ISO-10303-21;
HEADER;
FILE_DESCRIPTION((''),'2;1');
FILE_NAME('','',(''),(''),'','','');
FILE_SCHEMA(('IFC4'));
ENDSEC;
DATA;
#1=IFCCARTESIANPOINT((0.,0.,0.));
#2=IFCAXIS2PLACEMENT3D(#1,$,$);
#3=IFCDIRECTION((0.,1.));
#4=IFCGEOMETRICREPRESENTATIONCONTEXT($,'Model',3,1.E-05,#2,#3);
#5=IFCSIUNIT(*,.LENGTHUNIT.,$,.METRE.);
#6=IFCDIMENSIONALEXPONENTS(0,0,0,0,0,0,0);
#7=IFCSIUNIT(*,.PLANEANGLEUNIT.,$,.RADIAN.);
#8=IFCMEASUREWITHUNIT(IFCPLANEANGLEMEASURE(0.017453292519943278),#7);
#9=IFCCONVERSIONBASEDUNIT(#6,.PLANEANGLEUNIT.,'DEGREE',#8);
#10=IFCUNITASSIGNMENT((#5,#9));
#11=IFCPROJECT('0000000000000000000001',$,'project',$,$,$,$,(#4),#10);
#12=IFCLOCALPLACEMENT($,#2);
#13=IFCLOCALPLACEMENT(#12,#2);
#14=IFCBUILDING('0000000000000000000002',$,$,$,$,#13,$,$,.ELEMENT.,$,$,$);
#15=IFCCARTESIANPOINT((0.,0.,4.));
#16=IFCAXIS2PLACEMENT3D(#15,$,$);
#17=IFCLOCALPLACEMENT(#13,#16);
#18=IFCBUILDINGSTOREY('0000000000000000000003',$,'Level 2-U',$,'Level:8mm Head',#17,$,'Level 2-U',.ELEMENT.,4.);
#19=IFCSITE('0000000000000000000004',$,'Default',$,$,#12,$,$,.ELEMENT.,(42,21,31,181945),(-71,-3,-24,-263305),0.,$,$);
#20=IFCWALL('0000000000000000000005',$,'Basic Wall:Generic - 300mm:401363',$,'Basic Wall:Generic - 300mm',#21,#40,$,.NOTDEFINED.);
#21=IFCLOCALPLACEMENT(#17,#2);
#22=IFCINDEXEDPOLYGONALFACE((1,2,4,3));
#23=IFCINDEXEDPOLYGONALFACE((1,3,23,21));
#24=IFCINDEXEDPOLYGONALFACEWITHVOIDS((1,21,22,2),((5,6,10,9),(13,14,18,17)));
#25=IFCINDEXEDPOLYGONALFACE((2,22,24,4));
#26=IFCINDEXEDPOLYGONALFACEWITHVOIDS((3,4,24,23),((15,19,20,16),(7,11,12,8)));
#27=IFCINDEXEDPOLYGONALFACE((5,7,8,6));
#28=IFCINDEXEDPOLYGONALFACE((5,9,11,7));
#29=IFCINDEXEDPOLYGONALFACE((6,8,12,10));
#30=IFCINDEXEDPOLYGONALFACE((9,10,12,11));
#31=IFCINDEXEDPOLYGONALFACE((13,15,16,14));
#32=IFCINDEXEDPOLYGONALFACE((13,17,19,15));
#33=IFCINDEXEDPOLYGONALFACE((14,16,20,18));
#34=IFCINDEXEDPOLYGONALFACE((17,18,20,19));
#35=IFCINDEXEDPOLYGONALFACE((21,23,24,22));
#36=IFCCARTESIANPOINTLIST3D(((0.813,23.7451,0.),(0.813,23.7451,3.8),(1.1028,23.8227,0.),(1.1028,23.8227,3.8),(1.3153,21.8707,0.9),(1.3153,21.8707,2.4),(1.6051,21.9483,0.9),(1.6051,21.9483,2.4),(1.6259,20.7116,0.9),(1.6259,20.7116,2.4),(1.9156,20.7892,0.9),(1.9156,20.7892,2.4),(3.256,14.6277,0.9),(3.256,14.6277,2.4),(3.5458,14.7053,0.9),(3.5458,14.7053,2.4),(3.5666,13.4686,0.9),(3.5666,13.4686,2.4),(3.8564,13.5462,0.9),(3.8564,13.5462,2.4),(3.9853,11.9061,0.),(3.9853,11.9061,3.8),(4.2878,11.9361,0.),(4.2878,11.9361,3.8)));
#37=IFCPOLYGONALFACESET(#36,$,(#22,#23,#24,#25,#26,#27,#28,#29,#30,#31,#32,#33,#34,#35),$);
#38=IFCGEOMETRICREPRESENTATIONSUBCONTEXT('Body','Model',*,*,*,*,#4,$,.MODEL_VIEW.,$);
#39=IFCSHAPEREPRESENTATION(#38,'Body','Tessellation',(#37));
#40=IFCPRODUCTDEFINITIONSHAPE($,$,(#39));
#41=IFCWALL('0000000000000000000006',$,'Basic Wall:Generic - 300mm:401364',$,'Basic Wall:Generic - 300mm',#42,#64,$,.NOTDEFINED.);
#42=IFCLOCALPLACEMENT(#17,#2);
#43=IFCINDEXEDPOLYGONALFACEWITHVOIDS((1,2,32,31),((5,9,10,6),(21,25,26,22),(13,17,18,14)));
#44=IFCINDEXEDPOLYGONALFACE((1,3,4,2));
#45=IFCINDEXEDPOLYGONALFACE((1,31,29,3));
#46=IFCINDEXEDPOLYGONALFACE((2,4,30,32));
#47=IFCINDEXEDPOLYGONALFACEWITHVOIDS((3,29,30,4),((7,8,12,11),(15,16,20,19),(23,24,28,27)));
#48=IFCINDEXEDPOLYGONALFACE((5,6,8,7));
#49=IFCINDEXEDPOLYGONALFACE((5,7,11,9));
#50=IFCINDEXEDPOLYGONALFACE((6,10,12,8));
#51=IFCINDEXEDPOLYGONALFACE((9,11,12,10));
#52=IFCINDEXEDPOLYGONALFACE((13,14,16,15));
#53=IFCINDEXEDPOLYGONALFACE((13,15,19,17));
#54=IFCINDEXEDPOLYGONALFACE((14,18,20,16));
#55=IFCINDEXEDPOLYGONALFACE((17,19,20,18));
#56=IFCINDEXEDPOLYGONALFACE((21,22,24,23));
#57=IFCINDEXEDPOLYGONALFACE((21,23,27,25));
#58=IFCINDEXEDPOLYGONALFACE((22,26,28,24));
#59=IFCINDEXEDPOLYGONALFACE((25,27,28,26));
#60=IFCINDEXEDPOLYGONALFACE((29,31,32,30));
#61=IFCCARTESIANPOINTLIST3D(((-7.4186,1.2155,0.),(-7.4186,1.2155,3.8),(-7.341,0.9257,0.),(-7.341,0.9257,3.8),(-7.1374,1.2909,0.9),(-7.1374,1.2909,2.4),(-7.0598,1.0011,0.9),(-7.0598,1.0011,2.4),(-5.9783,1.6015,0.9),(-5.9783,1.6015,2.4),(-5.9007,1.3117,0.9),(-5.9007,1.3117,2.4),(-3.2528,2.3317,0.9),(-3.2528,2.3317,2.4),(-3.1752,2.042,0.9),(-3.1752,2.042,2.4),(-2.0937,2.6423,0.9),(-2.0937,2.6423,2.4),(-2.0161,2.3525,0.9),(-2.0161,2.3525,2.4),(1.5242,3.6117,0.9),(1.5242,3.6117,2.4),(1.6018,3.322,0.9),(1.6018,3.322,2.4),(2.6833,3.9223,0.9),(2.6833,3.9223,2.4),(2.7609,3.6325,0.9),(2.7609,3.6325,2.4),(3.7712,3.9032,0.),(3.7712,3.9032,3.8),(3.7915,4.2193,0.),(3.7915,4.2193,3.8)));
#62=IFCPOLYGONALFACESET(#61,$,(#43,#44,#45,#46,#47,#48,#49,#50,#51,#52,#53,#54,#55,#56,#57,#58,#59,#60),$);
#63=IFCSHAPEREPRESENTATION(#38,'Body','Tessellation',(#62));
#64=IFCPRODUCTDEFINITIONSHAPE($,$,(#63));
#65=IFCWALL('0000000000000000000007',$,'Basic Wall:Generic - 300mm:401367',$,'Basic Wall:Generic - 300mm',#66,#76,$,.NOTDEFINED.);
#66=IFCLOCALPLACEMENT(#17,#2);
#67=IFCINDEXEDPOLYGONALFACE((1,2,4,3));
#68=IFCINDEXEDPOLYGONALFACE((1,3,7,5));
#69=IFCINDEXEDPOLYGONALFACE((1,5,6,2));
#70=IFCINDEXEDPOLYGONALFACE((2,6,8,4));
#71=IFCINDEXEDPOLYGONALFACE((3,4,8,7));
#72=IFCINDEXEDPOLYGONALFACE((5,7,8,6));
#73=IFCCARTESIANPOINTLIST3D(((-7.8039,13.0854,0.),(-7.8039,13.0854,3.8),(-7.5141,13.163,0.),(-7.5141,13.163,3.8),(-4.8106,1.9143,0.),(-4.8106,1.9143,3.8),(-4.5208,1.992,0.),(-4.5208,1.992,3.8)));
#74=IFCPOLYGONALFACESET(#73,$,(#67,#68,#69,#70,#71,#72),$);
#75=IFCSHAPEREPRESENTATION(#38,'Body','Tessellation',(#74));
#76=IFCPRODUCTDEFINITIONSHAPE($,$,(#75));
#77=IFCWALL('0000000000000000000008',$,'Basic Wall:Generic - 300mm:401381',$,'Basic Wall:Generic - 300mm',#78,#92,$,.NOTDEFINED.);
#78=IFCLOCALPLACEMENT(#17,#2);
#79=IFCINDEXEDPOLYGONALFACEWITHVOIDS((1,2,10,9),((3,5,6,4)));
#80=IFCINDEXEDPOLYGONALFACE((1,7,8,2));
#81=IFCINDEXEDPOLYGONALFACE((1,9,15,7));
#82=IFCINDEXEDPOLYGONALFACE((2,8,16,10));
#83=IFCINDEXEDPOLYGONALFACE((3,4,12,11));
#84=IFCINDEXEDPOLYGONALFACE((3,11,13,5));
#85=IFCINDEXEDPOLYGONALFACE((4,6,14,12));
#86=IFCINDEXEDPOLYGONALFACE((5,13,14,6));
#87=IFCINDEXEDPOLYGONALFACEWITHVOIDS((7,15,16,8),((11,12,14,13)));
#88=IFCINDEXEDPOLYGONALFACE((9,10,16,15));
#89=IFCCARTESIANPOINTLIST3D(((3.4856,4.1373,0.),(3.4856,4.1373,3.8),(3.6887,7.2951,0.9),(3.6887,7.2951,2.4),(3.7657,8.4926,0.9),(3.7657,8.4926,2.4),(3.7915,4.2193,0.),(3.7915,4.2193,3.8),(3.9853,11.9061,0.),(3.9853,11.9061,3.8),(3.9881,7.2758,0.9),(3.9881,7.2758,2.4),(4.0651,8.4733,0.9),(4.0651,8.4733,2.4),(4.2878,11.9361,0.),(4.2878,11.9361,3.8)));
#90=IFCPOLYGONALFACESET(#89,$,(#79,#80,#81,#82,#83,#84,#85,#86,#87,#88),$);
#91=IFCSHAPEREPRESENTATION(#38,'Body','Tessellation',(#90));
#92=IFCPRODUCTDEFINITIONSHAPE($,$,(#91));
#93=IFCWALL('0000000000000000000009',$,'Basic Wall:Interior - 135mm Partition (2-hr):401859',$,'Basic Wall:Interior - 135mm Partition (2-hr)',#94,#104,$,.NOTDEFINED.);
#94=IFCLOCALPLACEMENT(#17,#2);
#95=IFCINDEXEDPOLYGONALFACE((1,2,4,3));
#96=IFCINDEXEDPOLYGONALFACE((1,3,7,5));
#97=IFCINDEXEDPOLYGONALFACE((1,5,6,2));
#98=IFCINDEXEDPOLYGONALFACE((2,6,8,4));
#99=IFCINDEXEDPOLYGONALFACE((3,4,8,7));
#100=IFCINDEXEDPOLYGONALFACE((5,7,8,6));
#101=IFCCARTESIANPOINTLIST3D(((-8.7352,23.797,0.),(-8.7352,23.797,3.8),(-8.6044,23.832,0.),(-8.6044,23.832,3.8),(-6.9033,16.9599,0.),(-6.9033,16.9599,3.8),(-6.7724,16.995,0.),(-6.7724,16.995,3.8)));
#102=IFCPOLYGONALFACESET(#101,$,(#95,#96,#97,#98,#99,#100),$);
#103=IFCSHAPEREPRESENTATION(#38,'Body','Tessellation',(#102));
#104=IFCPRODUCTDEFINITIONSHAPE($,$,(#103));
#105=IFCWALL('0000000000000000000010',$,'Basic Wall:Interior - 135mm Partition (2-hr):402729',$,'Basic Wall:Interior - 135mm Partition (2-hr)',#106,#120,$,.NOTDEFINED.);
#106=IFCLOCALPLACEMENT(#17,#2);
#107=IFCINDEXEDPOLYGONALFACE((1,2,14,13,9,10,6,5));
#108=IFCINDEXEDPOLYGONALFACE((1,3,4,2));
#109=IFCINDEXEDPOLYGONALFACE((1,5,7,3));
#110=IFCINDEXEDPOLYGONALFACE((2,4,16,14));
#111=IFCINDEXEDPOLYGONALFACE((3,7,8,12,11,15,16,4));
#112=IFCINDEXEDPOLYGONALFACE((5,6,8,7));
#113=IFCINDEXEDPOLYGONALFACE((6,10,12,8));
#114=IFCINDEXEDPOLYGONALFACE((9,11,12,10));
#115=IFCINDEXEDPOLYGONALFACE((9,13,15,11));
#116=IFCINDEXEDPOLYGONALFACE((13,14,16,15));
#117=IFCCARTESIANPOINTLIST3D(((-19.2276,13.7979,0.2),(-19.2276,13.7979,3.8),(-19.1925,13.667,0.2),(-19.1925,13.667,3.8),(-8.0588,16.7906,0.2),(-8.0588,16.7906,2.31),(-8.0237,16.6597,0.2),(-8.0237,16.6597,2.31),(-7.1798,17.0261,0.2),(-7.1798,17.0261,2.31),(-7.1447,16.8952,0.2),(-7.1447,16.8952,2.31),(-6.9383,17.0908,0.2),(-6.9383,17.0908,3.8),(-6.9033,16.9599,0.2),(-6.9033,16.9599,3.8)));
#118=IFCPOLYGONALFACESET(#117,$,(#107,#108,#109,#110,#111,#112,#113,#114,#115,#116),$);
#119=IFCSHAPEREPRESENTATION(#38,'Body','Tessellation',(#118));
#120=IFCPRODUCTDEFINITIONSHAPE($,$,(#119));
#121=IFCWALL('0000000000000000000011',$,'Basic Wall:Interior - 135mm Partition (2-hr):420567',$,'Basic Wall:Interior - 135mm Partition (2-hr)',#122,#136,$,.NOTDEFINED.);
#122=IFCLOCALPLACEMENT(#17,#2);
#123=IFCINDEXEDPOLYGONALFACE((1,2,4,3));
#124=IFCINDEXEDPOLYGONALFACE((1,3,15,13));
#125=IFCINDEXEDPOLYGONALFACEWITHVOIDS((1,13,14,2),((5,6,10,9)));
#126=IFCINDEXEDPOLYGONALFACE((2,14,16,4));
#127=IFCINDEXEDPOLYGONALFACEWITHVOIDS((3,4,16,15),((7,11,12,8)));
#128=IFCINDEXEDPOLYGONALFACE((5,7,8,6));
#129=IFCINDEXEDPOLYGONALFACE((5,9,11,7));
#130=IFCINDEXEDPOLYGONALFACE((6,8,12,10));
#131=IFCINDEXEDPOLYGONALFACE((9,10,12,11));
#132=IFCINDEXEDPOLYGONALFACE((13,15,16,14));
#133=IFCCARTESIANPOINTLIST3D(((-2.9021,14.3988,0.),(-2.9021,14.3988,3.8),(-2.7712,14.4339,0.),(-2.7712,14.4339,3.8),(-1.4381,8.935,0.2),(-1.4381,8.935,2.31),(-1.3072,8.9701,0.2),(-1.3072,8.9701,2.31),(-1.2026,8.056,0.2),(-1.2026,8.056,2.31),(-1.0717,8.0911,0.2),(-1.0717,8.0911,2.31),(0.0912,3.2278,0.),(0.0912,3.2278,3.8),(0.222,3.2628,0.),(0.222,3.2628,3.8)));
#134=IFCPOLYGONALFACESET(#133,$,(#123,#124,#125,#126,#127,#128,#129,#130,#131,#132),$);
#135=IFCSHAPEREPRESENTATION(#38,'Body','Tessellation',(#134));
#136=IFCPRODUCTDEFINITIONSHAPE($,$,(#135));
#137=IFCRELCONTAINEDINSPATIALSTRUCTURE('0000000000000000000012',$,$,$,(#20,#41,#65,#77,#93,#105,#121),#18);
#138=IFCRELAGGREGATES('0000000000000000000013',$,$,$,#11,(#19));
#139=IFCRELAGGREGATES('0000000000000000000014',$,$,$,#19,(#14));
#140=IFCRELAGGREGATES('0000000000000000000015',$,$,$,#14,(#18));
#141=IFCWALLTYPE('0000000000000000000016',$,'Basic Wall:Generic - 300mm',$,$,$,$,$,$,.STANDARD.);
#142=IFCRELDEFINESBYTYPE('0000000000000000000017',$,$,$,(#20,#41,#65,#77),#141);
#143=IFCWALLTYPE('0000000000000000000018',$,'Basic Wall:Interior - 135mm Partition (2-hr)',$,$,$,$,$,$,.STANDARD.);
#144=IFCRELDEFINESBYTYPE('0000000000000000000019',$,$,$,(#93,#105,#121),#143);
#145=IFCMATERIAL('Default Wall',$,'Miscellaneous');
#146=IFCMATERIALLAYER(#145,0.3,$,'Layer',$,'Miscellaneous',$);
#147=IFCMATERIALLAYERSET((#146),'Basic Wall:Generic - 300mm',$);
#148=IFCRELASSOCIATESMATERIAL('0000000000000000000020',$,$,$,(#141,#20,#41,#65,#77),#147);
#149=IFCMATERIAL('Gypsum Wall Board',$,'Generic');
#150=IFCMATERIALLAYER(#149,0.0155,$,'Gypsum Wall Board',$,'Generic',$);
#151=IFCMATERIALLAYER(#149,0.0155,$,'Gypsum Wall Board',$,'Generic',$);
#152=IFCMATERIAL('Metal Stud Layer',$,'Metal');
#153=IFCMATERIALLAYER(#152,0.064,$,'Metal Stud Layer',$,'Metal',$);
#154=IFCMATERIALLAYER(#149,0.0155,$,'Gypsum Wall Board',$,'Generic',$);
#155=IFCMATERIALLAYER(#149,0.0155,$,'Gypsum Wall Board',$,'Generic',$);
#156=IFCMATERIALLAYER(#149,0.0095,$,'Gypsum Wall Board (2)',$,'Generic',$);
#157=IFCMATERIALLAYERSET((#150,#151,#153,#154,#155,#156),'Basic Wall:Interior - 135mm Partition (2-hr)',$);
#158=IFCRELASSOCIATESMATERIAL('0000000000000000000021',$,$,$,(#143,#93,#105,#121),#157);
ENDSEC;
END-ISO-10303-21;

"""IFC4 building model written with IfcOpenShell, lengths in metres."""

from ifc_helpers import new_model, entity, si_unit, converted_unit, direction, frame, frame_2d, origin, place, context, subcontext, project, spatial, polyline, rectangle, outline, extrude, material, layer, layer_set, layer_usage, type_object, element, save


model = new_model("IFC4")

# Units and contexts
model_context = context("Model", 3, precision=1e-05, world=origin(), true_north=direction((0.0, 1.0)))
body_context = subcontext(model_context, "Body", "Model", "MODEL_VIEW")
ifc_project = project(units=[si_unit("LENGTHUNIT", "METRE"), converted_unit("PLANEANGLEUNIT", "DEGREE", entity("IfcPlaneAngleMeasure", 0.017453292519943278), si_unit("PLANEANGLEUNIT", "RADIAN"), dimensions=[0, 0, 0, 0, 0, 0, 0])], contexts=[model_context])

# Site, building, storey
site_placement = place(None, origin())
site = spatial("IfcSite", under=ifc_project, at=site_placement, Name="Default", CompositionType="ELEMENT", RefLatitude=(42, 21, 31, 181945), RefLongitude=(-71, -3, -24, -263305), RefElevation=0.0)
building_placement = place(site_placement, origin())
building = spatial("IfcBuilding", under=site, at=building_placement, CompositionType="ELEMENT")
storey_placement = place(building_placement, frame((0.0, 0.0, 4.0)))
storey = spatial("IfcBuildingStorey", under=building, at=storey_placement, Name="Level 2-U", ObjectType="Level:8mm Head", LongName="Level 2-U", CompositionType="ELEMENT", Elevation=4.0)

# Walls, openings
ifc_material_1 = material(Name="Default Wall", Category="Miscellaneous")
ifc_layer_1 = layer(ifc_material_1, 0.3, Name="Layer", Category="Miscellaneous")
ifc_layer_set_1 = layer_set([ifc_layer_1], Name="Basic Wall:Generic - 300mm")
ifc_layer_usage_1 = layer_usage(ifc_layer_set_1, "AXIS2", "POSITIVE", -0.15)
wall_type_1 = type_object("IfcWallType", Name="Basic Wall:Generic - 300mm", PredefinedType="STANDARD", material=ifc_layer_set_1)
wall_1_placement = place(storey_placement, frame((0.9579, 23.7839, 0.0), z_axis=(0.0, 0.0, 1.0), x_axis=(0.258819, -0.965926, 0.0)))
wall_1 = element("IfcWall", 1, at=wall_1_placement, inside=storey, type_object=wall_type_1, material=ifc_layer_usage_1, Name="Basic Wall:Generic - 300mm:401363", ObjectType="Basic Wall:Generic - 300mm", PredefinedType="NOTDEFINED", context=body_context, shape_type="SweptSolid", body=[
    extrude(outline(polyline([(12.2566, -0.15), (12.3059, 0.15), (0.0, 0.15), (0.0, -0.15), (12.2566, -0.15)])), origin(), (0.0, 0.0, 1.0), 3.8),
])
opening_1_placement = place(wall_1_placement, frame((1.9405, -0.15, 0.9)))
element("IfcOpeningElement", 2, at=opening_1_placement, cuts=wall_1, PredefinedType="OPENING", context=body_context, shape_type="SweptSolid", body=[
    extrude(rectangle(XDim=1.5, YDim=1.2, at=frame_2d((0.75, 0.6), x_axis=(-1.0, 0.0))), frame((0.0, 0.0, 0.0), z_axis=(0.0, 1.0, 0.0), x_axis=(0.0, 0.0, 1.0)), (0.0, 0.0, 1.0), 0.3),
])
opening_2_placement = place(wall_1_placement, frame((9.439, -0.15, 0.9)))
element("IfcOpeningElement", 3, at=opening_2_placement, cuts=wall_1, PredefinedType="OPENING", context=body_context, shape_type="SweptSolid", body=[
    extrude(rectangle(XDim=1.5, YDim=1.2, at=frame_2d((0.75, 0.6), x_axis=(-1.0, 0.0))), frame((0.0, 0.0, 0.0), z_axis=(0.0, 1.0, 0.0), x_axis=(0.0, 0.0, 1.0)), (0.0, 0.0, 1.0), 0.3),
])
ifc_layer_usage_2 = layer_usage(ifc_layer_set_1, "AXIS2", "NEGATIVE", 0.15)
wall_2_placement = place(storey_placement, frame((3.8303, 4.0744, 0.0), z_axis=(0.0, 0.0, 1.0), x_axis=(-0.965926, -0.258819, 0.0)))
wall_2 = element("IfcWall", 4, at=wall_2_placement, inside=storey, type_object=wall_type_1, material=ifc_layer_usage_2, Name="Basic Wall:Generic - 300mm:401364", ObjectType="Basic Wall:Generic - 300mm", PredefinedType="NOTDEFINED", context=body_context, shape_type="SweptSolid", body=[
    extrude(outline(polyline([(11.6056, -0.15), (11.6056, 0.15), (0.1014, 0.15), (0.0, -0.15), (0.3167, -0.15), (8.6056, -0.15), (8.9056, -0.15), (11.6056, -0.15)])), origin(), (0.0, 0.0, 1.0), 3.8),
])
opening_3_placement = place(wall_2_placement, frame((10.1144, -0.15, 0.9)))
element("IfcOpeningElement", 5, at=opening_3_placement, cuts=wall_2, PredefinedType="OPENING", context=body_context, shape_type="SweptSolid", body=[
    extrude(rectangle(XDim=1.5, YDim=1.2, at=frame_2d((0.75, 0.6), x_axis=(-1.0, 0.0))), frame((0.0, 0.0, 0.0), z_axis=(0.0, 1.0, 0.0), x_axis=(0.0, 0.0, 1.0)), (0.0, 0.0, 1.0), 0.3),
])
opening_4_placement = place(wall_2_placement, frame((6.0928, -0.15, 0.9)))
element("IfcOpeningElement", 6, at=opening_4_placement, cuts=wall_2, PredefinedType="OPENING", context=body_context, shape_type="SweptSolid", body=[
    extrude(rectangle(XDim=1.5, YDim=1.2, at=frame_2d((0.75, 0.6), x_axis=(-1.0, 0.0))), frame((0.0, 0.0, 0.0), z_axis=(0.0, 1.0, 0.0), x_axis=(0.0, 0.0, 1.0)), (0.0, 0.0, 1.0), 0.3),
])
opening_5_placement = place(wall_2_placement, frame((1.1473, -0.15, 0.9)))
element("IfcOpeningElement", 7, at=opening_5_placement, cuts=wall_2, PredefinedType="OPENING", context=body_context, shape_type="SweptSolid", body=[
    extrude(rectangle(XDim=1.5, YDim=1.2, at=frame_2d((0.75, 0.6), x_axis=(-1.0, 0.0))), frame((0.0, 0.0, 0.0), z_axis=(0.0, 1.0, 0.0), x_axis=(0.0, 0.0, 1.0)), (0.0, 0.0, 1.0), 0.3),
])

# Wall
wall_3_placement = place(storey_placement, frame((-7.659, 13.1242, 0.0), z_axis=(0.0, 0.0, 1.0), x_axis=(0.258819, -0.965926, 0.0)))
element("IfcWall", 8, at=wall_3_placement, inside=storey, type_object=wall_type_1, material=ifc_layer_usage_2, Name="Basic Wall:Generic - 300mm:401367", ObjectType="Basic Wall:Generic - 300mm", PredefinedType="NOTDEFINED", context=body_context, shape_type="SweptSolid", body=[
    extrude(rectangle(XDim=11.5651, YDim=0.3, at=frame_2d((5.7826, 0.0), x_axis=(-1.0, 0.0))), origin(), (0.0, 0.0, 1.0), 3.8),
])

# Wall, opening
wall_4_placement = place(storey_placement, frame((4.1381, 11.9457, 0.0), z_axis=(0.0, 0.0, 1.0), x_axis=(-0.064186, -0.997938, 0.0)))
wall_4 = element("IfcWall", 9, at=wall_4_placement, inside=storey, type_object=wall_type_1, material=ifc_layer_usage_2, Name="Basic Wall:Generic - 300mm:401381", ObjectType="Basic Wall:Generic - 300mm", PredefinedType="NOTDEFINED", context=body_context, shape_type="SweptSolid", body=[
    extrude(outline(polyline([(7.8342, -0.15), (7.7328, 0.15), (0.0, 0.15), (0.0493, -0.15), (7.8342, -0.15)])), origin(), (0.0, 0.0, 1.0), 3.8),
])
opening_6_placement = place(wall_4_placement, frame((3.4699, -0.15, 0.9)))
element("IfcOpeningElement", 10, at=opening_6_placement, cuts=wall_4, PredefinedType="OPENING", context=body_context, shape_type="SweptSolid", body=[
    extrude(rectangle(XDim=1.5, YDim=1.2, at=frame_2d((0.75, 0.6), x_axis=(-1.0, 0.0))), frame((0.0, 0.0, 0.0), z_axis=(0.0, 1.0, 0.0), x_axis=(0.0, 0.0, 1.0)), (0.0, 0.0, 1.0), 0.3),
])

# Wall
ifc_material_2 = material(Name="Gypsum Wall Board", Category="Generic")
ifc_layer_2 = layer(ifc_material_2, 0.0155, Name="Gypsum Wall Board", Category="Generic")
ifc_layer_3 = layer(ifc_material_2, 0.0155, Name="Gypsum Wall Board", Category="Generic")
ifc_material_3 = material(Name="Metal Stud Layer", Category="Metal")
ifc_layer_4 = layer(ifc_material_3, 0.064, Name="Metal Stud Layer", Category="Metal")
ifc_layer_5 = layer(ifc_material_2, 0.0155, Name="Gypsum Wall Board", Category="Generic")
ifc_layer_6 = layer(ifc_material_2, 0.0155, Name="Gypsum Wall Board", Category="Generic")
ifc_layer_7 = layer(ifc_material_2, 0.0095, Name="Gypsum Wall Board (2)", Category="Generic")
ifc_layer_set_2 = layer_set([ifc_layer_2, ifc_layer_3, ifc_layer_4, ifc_layer_5, ifc_layer_6, ifc_layer_7], Name="Basic Wall:Interior - 135mm Partition (2-hr)")
ifc_layer_usage_3 = layer_usage(ifc_layer_set_2, "AXIS2", "NEGATIVE", 0.0677)
wall_type_2 = type_object("IfcWallType", Name="Basic Wall:Interior - 135mm Partition (2-hr)", PredefinedType="STANDARD", material=ifc_layer_set_2)
wall_5_placement = place(storey_placement, frame((-6.8378, 16.9775, 0.0), z_axis=(0.0, 0.0, 1.0), x_axis=(-0.258819, 0.965926, 0.0)))
element("IfcWall", 11, at=wall_5_placement, inside=storey, type_object=wall_type_2, material=ifc_layer_usage_3, Name="Basic Wall:Interior - 135mm Partition (2-hr):401859", ObjectType="Basic Wall:Interior - 135mm Partition (2-hr)", PredefinedType="NOTDEFINED", context=body_context, shape_type="SweptSolid", body=[
    extrude(rectangle(XDim=7.0782, YDim=0.1355, at=frame_2d((3.5391, 0.0), x_axis=(-1.0, 0.0))), origin(), (0.0, 0.0, 1.0), 3.8),
])

# Walls, openings
wall_6_placement = place(storey_placement, frame((-6.9208, 17.0254, 0.2), z_axis=(0.0, 0.0, 1.0), x_axis=(-0.965926, -0.258819, 0.0)))
wall_6 = element("IfcWall", 12, at=wall_6_placement, inside=storey, type_object=wall_type_2, material=ifc_layer_usage_3, Name="Basic Wall:Interior - 135mm Partition (2-hr):402729", ObjectType="Basic Wall:Interior - 135mm Partition (2-hr)", PredefinedType="NOTDEFINED", context=body_context, shape_type="SweptSolid", body=[
    extrude(rectangle(XDim=12.7228, YDim=0.1355, at=frame_2d((6.3614, 0.0), x_axis=(1.0, 0.0))), origin(), (0.0, 0.0, 1.0), 3.6),
])
opening_7_placement = place(wall_6_placement, frame((0.25, -0.0678, 0.0)))
element("IfcOpeningElement", 13, at=opening_7_placement, cuts=wall_6, PredefinedType="OPENING", context=body_context, shape_type="SweptSolid", body=[
    extrude(rectangle(XDim=2.11, YDim=0.91, at=frame_2d((1.055, 0.455), x_axis=(1.0, 0.0))), frame((0.0, 0.0, 0.0), z_axis=(0.0, 1.0, 0.0), x_axis=(0.0, 0.0, 1.0)), (0.0, 0.0, 1.0), 0.1355),
])
wall_7_placement = place(storey_placement, frame((0.1566, 3.2453, 0.0), z_axis=(0.0, 0.0, 1.0), x_axis=(-0.258819, 0.965926, 0.0)))
wall_7 = element("IfcWall", 14, at=wall_7_placement, inside=storey, type_object=wall_type_2, material=ifc_layer_usage_3, Name="Basic Wall:Interior - 135mm Partition (2-hr):420567", ObjectType="Basic Wall:Interior - 135mm Partition (2-hr)", PredefinedType="NOTDEFINED", context=body_context, shape_type="SweptSolid", body=[
    extrude(rectangle(XDim=11.5651, YDim=0.1355, at=frame_2d((5.7826, 0.0), x_axis=(-1.0, 0.0))), origin(), (0.0, 0.0, 1.0), 3.8),
])
opening_8_placement = place(wall_7_placement, frame((4.9986, -0.0678, 0.2)))
element("IfcOpeningElement", 15, at=opening_8_placement, cuts=wall_7, PredefinedType="OPENING", context=body_context, shape_type="SweptSolid", body=[
    extrude(rectangle(XDim=2.11, YDim=0.91, at=frame_2d((1.055, 0.455), x_axis=(1.0, 0.0))), frame((0.0, 0.0, 0.0), z_axis=(0.0, 1.0, 0.0), x_axis=(0.0, 0.0, 1.0)), (0.0, 0.0, 1.0), 0.1355),
])

save(model, "model.ifc")
